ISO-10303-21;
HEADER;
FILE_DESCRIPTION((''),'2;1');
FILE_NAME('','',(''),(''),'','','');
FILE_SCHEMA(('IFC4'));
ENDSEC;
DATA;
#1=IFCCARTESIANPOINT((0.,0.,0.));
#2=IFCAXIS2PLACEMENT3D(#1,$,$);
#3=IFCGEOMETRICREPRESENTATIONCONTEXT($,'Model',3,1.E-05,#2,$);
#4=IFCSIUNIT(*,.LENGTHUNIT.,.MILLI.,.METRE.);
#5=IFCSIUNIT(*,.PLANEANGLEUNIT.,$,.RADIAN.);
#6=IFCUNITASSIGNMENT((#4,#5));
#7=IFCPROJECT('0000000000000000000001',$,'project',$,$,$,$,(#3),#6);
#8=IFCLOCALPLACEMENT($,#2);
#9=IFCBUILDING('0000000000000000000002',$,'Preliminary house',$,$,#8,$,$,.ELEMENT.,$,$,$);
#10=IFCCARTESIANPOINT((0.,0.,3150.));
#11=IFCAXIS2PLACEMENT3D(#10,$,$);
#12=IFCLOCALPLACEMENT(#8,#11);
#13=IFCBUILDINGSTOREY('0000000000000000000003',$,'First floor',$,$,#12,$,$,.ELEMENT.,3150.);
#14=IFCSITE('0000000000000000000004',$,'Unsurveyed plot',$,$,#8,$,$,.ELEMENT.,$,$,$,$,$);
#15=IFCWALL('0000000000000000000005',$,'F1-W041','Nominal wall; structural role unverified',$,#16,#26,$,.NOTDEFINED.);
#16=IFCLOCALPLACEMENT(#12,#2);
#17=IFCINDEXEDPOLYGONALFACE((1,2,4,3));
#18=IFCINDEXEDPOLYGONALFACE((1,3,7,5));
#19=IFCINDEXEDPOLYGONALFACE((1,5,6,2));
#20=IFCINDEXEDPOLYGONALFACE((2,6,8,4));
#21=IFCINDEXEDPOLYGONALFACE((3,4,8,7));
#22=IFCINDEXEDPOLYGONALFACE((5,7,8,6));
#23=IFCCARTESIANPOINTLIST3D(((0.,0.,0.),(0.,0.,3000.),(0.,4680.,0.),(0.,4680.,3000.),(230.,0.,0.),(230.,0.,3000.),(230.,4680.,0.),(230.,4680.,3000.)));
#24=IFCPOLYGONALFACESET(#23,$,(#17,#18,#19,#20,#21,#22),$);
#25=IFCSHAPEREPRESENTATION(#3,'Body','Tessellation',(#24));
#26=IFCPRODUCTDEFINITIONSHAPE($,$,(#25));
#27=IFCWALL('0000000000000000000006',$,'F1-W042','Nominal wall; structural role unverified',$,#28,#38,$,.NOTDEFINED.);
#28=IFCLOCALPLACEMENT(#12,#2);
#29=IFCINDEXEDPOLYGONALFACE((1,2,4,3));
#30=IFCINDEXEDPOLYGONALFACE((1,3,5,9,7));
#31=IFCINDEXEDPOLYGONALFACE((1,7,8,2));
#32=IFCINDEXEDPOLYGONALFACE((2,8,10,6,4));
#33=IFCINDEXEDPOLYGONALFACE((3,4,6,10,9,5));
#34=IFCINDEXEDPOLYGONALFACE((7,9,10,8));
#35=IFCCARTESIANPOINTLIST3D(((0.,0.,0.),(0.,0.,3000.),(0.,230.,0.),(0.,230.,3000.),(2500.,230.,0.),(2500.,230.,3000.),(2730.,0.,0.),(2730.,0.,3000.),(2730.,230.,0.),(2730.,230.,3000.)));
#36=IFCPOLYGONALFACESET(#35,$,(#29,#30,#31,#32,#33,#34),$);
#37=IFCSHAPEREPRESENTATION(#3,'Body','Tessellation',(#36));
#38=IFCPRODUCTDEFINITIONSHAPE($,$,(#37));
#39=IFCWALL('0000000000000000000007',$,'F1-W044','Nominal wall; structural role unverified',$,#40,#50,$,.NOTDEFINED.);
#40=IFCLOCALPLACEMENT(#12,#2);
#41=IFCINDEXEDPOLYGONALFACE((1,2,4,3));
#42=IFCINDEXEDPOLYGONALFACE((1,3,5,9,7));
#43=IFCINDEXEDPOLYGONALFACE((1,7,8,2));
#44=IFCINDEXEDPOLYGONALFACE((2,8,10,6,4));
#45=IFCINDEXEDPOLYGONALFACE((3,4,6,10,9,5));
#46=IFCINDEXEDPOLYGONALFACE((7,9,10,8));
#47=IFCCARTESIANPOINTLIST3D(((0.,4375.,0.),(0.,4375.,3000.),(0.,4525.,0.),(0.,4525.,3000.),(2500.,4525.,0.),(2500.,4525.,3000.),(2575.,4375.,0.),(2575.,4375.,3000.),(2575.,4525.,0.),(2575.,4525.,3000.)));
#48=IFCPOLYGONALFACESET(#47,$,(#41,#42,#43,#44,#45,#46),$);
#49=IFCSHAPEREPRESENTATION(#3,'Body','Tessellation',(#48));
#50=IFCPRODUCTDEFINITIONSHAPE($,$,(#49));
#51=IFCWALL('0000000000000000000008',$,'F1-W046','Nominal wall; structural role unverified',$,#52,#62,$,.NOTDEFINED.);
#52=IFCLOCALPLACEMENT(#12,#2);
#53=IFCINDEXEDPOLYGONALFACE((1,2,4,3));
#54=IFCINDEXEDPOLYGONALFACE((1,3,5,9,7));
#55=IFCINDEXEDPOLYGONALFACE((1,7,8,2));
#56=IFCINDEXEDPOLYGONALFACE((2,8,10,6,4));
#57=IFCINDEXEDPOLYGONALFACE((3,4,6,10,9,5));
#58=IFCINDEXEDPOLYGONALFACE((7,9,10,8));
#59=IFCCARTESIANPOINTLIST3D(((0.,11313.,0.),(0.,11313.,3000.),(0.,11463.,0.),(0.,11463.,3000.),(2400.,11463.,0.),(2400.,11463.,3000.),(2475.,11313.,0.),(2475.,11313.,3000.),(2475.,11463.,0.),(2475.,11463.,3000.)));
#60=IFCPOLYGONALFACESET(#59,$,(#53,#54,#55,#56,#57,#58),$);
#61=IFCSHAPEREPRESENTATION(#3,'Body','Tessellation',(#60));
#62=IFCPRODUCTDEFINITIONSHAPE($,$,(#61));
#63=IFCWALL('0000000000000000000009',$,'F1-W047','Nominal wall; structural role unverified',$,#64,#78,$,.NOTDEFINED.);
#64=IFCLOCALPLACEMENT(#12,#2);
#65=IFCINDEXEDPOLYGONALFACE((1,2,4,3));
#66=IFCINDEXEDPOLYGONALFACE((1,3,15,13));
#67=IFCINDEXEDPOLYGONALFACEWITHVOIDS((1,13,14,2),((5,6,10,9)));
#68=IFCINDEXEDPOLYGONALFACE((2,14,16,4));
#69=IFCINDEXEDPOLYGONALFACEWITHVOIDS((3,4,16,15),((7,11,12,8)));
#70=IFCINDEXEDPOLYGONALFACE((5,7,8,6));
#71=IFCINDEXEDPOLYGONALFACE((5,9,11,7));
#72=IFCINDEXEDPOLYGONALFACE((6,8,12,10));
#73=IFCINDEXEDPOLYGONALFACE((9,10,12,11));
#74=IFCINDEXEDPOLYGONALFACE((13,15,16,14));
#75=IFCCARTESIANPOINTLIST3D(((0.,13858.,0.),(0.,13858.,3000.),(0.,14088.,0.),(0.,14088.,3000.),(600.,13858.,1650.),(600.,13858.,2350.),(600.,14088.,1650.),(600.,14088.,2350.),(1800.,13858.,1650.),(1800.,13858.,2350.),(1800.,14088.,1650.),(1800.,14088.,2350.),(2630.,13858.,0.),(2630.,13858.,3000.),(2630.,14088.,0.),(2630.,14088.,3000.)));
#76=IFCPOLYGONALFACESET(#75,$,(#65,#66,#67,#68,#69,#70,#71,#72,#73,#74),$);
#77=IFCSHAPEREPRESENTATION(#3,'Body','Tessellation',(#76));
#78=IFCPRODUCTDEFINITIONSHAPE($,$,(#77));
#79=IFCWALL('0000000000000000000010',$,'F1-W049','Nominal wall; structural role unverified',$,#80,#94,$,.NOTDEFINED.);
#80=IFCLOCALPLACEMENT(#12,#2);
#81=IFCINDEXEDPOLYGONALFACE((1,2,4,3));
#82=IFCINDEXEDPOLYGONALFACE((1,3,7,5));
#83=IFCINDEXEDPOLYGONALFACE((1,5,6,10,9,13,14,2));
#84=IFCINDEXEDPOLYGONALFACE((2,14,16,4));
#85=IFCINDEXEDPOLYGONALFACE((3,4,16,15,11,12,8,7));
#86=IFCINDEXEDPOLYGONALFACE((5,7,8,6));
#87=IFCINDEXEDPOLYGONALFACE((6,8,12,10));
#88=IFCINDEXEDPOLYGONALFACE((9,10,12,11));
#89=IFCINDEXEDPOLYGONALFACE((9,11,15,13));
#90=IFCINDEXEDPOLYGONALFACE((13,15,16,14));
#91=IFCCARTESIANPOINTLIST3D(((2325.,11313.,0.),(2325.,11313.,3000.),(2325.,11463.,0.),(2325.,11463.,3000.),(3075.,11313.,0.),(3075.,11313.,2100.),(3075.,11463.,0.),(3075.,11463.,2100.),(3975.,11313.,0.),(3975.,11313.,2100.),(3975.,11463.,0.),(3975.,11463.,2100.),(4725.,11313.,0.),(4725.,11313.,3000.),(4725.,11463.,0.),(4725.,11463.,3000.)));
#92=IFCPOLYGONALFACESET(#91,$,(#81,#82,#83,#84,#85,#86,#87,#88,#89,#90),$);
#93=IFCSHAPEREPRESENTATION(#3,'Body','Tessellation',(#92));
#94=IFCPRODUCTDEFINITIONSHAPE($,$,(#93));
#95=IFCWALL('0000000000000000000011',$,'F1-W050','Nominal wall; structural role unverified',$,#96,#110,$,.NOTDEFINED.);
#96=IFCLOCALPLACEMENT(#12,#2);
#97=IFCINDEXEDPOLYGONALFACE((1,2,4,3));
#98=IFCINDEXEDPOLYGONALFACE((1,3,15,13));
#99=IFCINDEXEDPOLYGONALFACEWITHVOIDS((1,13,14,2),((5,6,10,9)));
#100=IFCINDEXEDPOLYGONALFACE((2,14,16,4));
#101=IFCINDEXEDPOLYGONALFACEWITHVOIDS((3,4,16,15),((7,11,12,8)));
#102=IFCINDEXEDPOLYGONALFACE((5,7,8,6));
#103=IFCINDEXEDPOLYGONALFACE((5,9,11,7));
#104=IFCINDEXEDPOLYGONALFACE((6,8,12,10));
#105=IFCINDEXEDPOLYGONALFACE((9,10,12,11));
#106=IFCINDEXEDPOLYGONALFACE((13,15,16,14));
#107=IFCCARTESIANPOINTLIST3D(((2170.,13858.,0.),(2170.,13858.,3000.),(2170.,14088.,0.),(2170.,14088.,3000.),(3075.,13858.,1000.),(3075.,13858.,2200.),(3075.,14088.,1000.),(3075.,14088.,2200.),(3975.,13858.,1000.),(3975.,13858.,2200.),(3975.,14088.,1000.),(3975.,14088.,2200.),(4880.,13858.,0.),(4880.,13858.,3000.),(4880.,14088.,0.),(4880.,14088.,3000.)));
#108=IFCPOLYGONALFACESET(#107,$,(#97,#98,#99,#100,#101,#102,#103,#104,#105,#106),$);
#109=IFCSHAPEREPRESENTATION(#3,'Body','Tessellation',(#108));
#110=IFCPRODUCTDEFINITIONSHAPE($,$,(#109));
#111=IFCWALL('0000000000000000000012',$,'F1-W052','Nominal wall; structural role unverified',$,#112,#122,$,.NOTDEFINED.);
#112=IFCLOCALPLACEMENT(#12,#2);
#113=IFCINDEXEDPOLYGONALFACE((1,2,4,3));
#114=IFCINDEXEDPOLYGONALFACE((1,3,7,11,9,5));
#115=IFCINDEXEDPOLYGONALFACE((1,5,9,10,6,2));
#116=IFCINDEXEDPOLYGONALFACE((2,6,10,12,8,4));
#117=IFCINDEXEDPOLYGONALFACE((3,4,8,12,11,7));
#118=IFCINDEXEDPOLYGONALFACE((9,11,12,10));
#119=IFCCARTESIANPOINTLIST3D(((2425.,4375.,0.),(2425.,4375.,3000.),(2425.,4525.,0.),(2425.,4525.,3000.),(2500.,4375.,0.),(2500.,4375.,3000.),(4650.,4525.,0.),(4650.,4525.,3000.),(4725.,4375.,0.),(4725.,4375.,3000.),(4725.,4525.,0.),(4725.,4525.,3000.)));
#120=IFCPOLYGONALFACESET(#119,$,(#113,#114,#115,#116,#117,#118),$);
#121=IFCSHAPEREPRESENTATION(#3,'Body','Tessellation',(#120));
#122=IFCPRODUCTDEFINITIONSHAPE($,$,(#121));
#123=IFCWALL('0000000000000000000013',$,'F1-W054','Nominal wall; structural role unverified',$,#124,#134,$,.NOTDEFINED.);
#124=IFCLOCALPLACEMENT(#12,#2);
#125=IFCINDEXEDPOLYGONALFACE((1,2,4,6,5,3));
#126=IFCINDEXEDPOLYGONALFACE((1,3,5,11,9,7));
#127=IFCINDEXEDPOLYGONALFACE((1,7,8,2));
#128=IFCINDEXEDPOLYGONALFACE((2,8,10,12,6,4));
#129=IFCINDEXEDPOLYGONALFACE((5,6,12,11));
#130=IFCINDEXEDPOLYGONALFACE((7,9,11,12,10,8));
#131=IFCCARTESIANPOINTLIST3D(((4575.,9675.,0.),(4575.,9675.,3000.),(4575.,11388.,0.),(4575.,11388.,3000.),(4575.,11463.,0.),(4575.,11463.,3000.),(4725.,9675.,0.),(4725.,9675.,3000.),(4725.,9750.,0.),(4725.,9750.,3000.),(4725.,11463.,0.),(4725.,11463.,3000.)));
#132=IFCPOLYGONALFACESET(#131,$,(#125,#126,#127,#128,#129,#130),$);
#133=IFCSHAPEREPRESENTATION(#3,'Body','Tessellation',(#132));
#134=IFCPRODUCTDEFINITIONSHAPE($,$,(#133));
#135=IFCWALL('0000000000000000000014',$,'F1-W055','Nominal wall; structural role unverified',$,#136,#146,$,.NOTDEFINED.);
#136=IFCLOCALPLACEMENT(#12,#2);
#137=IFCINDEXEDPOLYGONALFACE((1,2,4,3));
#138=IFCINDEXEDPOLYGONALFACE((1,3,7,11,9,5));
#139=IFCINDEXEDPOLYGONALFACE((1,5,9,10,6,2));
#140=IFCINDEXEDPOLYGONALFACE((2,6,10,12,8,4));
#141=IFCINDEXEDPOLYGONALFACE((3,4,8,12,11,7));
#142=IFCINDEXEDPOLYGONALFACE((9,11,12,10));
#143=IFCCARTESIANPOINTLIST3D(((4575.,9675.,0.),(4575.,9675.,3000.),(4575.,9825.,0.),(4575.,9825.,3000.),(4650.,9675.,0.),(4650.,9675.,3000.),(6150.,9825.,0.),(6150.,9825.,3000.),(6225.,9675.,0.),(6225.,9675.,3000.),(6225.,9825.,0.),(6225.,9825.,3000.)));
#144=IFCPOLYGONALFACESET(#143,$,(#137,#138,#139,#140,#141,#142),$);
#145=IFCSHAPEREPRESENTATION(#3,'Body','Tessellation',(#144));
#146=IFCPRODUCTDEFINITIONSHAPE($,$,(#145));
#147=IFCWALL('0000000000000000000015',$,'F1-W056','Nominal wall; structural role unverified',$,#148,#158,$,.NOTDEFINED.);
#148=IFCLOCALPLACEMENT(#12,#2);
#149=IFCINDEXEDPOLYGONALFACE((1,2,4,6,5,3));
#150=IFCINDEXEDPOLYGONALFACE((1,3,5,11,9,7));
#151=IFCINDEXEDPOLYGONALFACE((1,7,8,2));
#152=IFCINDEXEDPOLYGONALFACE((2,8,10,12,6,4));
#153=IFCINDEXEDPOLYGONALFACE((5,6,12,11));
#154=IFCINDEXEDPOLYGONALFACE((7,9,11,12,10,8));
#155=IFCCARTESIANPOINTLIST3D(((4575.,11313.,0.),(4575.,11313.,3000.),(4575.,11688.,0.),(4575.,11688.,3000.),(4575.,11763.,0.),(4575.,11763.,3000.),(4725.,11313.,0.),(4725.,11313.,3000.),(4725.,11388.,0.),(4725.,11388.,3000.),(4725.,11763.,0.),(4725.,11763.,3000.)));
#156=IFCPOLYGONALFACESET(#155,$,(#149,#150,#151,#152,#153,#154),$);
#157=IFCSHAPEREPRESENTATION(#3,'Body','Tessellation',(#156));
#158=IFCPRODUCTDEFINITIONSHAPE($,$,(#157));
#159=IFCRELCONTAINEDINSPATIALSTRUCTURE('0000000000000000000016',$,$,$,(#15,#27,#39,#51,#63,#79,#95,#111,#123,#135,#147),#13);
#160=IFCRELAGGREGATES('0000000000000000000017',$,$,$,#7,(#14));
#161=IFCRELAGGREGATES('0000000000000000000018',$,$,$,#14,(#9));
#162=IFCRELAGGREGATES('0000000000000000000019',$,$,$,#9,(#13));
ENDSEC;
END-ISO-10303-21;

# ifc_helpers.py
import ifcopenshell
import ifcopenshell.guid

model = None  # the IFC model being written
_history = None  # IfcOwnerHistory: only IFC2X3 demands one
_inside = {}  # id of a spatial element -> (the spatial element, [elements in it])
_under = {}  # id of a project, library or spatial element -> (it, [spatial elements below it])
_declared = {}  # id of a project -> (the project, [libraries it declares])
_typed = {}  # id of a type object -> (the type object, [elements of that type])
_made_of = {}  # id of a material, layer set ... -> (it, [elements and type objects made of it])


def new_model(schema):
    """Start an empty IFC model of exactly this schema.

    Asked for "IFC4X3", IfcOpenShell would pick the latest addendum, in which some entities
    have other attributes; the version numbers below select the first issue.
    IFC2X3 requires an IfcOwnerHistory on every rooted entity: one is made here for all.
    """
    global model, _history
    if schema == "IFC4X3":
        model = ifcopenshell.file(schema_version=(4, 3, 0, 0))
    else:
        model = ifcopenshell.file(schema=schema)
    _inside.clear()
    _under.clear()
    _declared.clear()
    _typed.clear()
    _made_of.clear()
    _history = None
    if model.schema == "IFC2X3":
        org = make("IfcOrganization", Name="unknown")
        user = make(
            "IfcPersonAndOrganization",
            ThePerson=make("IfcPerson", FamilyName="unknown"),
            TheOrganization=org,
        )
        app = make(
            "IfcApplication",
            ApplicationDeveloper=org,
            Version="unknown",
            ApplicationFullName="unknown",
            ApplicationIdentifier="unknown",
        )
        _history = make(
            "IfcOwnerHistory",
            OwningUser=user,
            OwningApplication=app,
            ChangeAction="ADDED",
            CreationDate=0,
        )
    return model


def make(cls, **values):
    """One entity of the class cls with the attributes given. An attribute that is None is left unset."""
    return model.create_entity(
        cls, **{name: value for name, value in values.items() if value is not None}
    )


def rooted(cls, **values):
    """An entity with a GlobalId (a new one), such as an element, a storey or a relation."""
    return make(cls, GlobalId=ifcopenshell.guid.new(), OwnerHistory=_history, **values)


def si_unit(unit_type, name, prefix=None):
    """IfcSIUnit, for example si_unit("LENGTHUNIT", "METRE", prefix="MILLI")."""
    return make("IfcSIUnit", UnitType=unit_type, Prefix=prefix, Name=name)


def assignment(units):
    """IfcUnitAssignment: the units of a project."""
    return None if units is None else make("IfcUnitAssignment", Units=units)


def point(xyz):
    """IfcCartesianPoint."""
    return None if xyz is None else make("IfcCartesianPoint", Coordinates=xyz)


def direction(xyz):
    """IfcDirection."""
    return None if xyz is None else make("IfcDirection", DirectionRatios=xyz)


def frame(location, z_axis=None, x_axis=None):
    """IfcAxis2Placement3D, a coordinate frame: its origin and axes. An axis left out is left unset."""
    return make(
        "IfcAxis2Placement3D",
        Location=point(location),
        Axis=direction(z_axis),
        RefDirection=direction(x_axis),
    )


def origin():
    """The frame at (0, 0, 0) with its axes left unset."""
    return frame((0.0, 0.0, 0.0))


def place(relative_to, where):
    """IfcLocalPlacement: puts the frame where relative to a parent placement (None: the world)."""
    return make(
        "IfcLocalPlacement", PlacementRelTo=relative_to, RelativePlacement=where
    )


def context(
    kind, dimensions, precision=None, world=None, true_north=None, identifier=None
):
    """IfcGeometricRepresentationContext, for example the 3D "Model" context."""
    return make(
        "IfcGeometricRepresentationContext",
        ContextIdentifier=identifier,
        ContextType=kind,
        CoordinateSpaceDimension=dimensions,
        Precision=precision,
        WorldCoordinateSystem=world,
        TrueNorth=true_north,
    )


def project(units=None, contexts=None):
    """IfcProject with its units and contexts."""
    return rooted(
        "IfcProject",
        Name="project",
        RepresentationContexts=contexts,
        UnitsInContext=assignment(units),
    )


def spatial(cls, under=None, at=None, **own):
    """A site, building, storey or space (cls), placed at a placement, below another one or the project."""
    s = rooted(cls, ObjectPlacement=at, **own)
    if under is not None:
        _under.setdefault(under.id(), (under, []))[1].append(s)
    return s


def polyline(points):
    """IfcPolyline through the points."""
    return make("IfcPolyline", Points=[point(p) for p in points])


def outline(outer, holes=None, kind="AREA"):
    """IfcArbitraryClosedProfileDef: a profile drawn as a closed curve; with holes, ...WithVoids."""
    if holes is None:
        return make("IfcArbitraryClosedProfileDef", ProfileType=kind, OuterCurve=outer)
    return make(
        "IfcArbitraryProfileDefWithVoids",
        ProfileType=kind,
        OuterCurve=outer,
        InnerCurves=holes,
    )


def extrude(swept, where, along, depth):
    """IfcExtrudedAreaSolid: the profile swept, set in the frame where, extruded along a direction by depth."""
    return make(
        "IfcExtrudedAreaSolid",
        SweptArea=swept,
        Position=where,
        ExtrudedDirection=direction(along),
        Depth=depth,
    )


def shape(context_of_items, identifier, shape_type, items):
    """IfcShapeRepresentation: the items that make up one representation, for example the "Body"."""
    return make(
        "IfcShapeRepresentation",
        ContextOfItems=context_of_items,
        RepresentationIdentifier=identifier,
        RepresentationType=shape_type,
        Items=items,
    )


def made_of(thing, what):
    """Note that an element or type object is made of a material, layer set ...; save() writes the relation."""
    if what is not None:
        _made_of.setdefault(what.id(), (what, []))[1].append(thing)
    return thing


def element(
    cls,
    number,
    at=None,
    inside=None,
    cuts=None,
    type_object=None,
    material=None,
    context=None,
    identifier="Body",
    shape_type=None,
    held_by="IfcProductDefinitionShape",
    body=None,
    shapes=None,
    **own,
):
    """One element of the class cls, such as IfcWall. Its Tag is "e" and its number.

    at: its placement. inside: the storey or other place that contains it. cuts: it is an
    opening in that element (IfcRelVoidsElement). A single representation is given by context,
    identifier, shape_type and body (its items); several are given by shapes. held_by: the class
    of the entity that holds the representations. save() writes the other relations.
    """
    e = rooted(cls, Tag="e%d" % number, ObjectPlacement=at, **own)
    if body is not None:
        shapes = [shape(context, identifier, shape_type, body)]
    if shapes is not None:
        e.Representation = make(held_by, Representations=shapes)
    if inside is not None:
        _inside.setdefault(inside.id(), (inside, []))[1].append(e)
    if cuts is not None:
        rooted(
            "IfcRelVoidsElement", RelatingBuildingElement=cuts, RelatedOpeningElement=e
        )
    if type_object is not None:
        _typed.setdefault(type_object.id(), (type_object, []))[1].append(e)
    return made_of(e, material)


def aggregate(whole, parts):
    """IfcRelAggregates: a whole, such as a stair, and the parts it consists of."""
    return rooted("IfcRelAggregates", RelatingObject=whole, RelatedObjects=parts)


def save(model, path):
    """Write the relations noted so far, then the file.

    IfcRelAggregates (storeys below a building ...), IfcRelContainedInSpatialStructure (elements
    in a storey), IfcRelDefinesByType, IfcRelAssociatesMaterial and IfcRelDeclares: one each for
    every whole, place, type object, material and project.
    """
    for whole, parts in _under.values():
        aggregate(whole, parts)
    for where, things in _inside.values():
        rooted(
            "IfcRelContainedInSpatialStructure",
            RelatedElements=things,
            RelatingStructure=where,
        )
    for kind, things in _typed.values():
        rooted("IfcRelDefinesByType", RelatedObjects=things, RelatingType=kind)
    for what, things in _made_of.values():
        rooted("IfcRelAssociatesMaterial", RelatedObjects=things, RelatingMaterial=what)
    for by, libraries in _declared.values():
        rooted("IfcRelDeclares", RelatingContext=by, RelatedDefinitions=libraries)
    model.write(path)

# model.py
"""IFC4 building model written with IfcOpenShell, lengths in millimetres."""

from ifc_helpers import new_model, si_unit, frame, origin, place, context, project, spatial, polyline, outline, extrude, element, save


model = new_model("IFC4")

# Units and contexts
model_context = context("Model", 3, precision=1e-05, world=origin())
ifc_project = project(units=[si_unit("LENGTHUNIT", "METRE", prefix="MILLI"), si_unit("PLANEANGLEUNIT", "RADIAN")], contexts=[model_context])

# Site, building, storey
placement_1 = place(None, origin())
site = spatial("IfcSite", under=ifc_project, at=placement_1, Name="Unsurveyed plot", CompositionType="ELEMENT")
building = spatial("IfcBuilding", under=site, at=placement_1, Name="Preliminary house", CompositionType="ELEMENT")
placement_2 = place(placement_1, frame((0.0, 0.0, 3150.0)))
storey = spatial("IfcBuildingStorey", under=building, at=placement_2, Name="First floor", CompositionType="ELEMENT", Elevation=3150.0)

# Walls
element("IfcWall", 1, at=placement_2, inside=storey, Name="F1-W041", Description="Nominal wall; structural role unverified", PredefinedType="NOTDEFINED", context=model_context, shape_type="SweptSolid", body=[
    extrude(outline(polyline([(230.0, 4680.0), (230.0, 0.0), (0.0, 0.0), (0.0, 4680.0), (230.0, 4680.0)])), origin(), (0.0, 0.0, 1.0), 3000.0),
])
element("IfcWall", 2, at=placement_2, inside=storey, Name="F1-W042", Description="Nominal wall; structural role unverified", PredefinedType="NOTDEFINED", context=model_context, shape_type="SweptSolid", body=[
    extrude(outline(polyline([(2730.0, 230.0), (2730.0, 0.0), (0.0, 0.0), (0.0, 230.0), (2500.0, 230.0), (2730.0, 230.0)])), origin(), (0.0, 0.0, 1.0), 3000.0),
])

# Wall
element("IfcWall", 3, at=placement_2, inside=storey, Name="F1-W044", Description="Nominal wall; structural role unverified", PredefinedType="NOTDEFINED", context=model_context, shape_type="SweptSolid", body=[
    extrude(outline(polyline([(2575.0, 4525.0), (2575.0, 4375.0), (0.0, 4375.0), (0.0, 4525.0), (2500.0, 4525.0), (2575.0, 4525.0)])), origin(), (0.0, 0.0, 1.0), 3000.0),
])

# Wall
element("IfcWall", 4, at=placement_2, inside=storey, Name="F1-W046", Description="Nominal wall; structural role unverified", PredefinedType="NOTDEFINED", context=model_context, shape_type="SweptSolid", body=[
    extrude(outline(polyline([(2475.0, 11463.0), (2475.0, 11313.0), (0.0, 11313.0), (0.0, 11463.0), (2400.0, 11463.0), (2475.0, 11463.0)])), origin(), (0.0, 0.0, 1.0), 3000.0),
])

# Walls, openings
wall_1 = element("IfcWall", 5, at=placement_2, inside=storey, Name="F1-W047", Description="Nominal wall; structural role unverified", PredefinedType="NOTDEFINED", context=model_context, shape_type="SweptSolid", body=[
    extrude(outline(polyline([(2630.0, 13858.0), (0.0, 13858.0), (0.0, 14088.0), (2630.0, 14088.0), (2630.0, 13858.0)])), origin(), (0.0, 0.0, 1.0), 3000.0),
])
element("IfcOpeningElement", 6, at=placement_2, cuts=wall_1, PredefinedType="OPENING", context=model_context, shape_type="SweptSolid", body=[
    extrude(outline(polyline([(600.0, 13443.0), (1800.0, 13443.0), (1800.0, 14503.0), (600.0, 14503.0), (600.0, 13443.0)])), frame((0.0, 0.0, 1650.0)), (0.0, 0.0, 1.0), 700.0),
])
wall_2 = element("IfcWall", 7, at=placement_2, inside=storey, Name="F1-W049", Description="Nominal wall; structural role unverified", PredefinedType="NOTDEFINED", context=model_context, shape_type="SweptSolid", body=[
    extrude(outline(polyline([(4725.0, 11463.0), (4725.0, 11313.0), (2400.0, 11313.0), (2325.0, 11313.0), (2325.0, 11463.0), (4650.0, 11463.0), (4725.0, 11463.0)])), origin(), (0.0, 0.0, 1.0), 3000.0),
])
element("IfcOpeningElement", 8, at=placement_2, cuts=wall_2, PredefinedType="OPENING", context=model_context, shape_type="SweptSolid", body=[
    extrude(outline(polyline([(3075.0, 10938.0), (3975.0, 10938.0), (3975.0, 11838.0), (3075.0, 11838.0), (3075.0, 10938.0)])), origin(), (0.0, 0.0, 1.0), 2100.0),
])
wall_3 = element("IfcWall", 9, at=placement_2, inside=storey, Name="F1-W050", Description="Nominal wall; structural role unverified", PredefinedType="NOTDEFINED", context=model_context, shape_type="SweptSolid", body=[
    extrude(outline(polyline([(4880.0, 13858.0), (2400.0, 13858.0), (2170.0, 13858.0), (2170.0, 14088.0), (4880.0, 14088.0), (4880.0, 13858.0)])), origin(), (0.0, 0.0, 1.0), 3000.0),
])
element("IfcOpeningElement", 10, at=placement_2, cuts=wall_3, PredefinedType="OPENING", context=model_context, shape_type="SweptSolid", body=[
    extrude(outline(polyline([(3075.0, 13443.0), (3975.0, 13443.0), (3975.0, 14503.0), (3075.0, 14503.0), (3075.0, 13443.0)])), frame((0.0, 0.0, 1000.0)), (0.0, 0.0, 1.0), 1200.0),
])

# Wall
element("IfcWall", 11, at=placement_2, inside=storey, Name="F1-W052", Description="Nominal wall; structural role unverified", PredefinedType="NOTDEFINED", context=model_context, shape_type="SweptSolid", body=[
    extrude(outline(polyline([(4725.0, 4525.0), (4725.0, 4375.0), (2500.0, 4375.0), (2425.0, 4375.0), (2425.0, 4525.0), (4650.0, 4525.0), (4725.0, 4525.0)])), origin(), (0.0, 0.0, 1.0), 3000.0),
])

# Walls
element("IfcWall", 12, at=placement_2, inside=storey, Name="F1-W054", Description="Nominal wall; structural role unverified", PredefinedType="NOTDEFINED", context=model_context, shape_type="SweptSolid", body=[
    extrude(outline(polyline([(4575.0, 11463.0), (4725.0, 11463.0), (4725.0, 9750.0), (4725.0, 9675.0), (4575.0, 9675.0), (4575.0, 11388.0), (4575.0, 11463.0)])), origin(), (0.0, 0.0, 1.0), 3000.0),
])
element("IfcWall", 13, at=placement_2, inside=storey, Name="F1-W055", Description="Nominal wall; structural role unverified", PredefinedType="NOTDEFINED", context=model_context, shape_type="SweptSolid", body=[
    extrude(outline(polyline([(6225.0, 9825.0), (6225.0, 9675.0), (4650.0, 9675.0), (4575.0, 9675.0), (4575.0, 9825.0), (6150.0, 9825.0), (6225.0, 9825.0)])), origin(), (0.0, 0.0, 1.0), 3000.0),
])
element("IfcWall", 14, at=placement_2, inside=storey, Name="F1-W056", Description="Nominal wall; structural role unverified", PredefinedType="NOTDEFINED", context=model_context, shape_type="SweptSolid", body=[
    extrude(outline(polyline([(4575.0, 11763.0), (4725.0, 11763.0), (4725.0, 11388.0), (4725.0, 11313.0), (4575.0, 11313.0), (4575.0, 11688.0), (4575.0, 11763.0)])), origin(), (0.0, 0.0, 1.0), 3000.0),
])

save(model, "model.ifc")
